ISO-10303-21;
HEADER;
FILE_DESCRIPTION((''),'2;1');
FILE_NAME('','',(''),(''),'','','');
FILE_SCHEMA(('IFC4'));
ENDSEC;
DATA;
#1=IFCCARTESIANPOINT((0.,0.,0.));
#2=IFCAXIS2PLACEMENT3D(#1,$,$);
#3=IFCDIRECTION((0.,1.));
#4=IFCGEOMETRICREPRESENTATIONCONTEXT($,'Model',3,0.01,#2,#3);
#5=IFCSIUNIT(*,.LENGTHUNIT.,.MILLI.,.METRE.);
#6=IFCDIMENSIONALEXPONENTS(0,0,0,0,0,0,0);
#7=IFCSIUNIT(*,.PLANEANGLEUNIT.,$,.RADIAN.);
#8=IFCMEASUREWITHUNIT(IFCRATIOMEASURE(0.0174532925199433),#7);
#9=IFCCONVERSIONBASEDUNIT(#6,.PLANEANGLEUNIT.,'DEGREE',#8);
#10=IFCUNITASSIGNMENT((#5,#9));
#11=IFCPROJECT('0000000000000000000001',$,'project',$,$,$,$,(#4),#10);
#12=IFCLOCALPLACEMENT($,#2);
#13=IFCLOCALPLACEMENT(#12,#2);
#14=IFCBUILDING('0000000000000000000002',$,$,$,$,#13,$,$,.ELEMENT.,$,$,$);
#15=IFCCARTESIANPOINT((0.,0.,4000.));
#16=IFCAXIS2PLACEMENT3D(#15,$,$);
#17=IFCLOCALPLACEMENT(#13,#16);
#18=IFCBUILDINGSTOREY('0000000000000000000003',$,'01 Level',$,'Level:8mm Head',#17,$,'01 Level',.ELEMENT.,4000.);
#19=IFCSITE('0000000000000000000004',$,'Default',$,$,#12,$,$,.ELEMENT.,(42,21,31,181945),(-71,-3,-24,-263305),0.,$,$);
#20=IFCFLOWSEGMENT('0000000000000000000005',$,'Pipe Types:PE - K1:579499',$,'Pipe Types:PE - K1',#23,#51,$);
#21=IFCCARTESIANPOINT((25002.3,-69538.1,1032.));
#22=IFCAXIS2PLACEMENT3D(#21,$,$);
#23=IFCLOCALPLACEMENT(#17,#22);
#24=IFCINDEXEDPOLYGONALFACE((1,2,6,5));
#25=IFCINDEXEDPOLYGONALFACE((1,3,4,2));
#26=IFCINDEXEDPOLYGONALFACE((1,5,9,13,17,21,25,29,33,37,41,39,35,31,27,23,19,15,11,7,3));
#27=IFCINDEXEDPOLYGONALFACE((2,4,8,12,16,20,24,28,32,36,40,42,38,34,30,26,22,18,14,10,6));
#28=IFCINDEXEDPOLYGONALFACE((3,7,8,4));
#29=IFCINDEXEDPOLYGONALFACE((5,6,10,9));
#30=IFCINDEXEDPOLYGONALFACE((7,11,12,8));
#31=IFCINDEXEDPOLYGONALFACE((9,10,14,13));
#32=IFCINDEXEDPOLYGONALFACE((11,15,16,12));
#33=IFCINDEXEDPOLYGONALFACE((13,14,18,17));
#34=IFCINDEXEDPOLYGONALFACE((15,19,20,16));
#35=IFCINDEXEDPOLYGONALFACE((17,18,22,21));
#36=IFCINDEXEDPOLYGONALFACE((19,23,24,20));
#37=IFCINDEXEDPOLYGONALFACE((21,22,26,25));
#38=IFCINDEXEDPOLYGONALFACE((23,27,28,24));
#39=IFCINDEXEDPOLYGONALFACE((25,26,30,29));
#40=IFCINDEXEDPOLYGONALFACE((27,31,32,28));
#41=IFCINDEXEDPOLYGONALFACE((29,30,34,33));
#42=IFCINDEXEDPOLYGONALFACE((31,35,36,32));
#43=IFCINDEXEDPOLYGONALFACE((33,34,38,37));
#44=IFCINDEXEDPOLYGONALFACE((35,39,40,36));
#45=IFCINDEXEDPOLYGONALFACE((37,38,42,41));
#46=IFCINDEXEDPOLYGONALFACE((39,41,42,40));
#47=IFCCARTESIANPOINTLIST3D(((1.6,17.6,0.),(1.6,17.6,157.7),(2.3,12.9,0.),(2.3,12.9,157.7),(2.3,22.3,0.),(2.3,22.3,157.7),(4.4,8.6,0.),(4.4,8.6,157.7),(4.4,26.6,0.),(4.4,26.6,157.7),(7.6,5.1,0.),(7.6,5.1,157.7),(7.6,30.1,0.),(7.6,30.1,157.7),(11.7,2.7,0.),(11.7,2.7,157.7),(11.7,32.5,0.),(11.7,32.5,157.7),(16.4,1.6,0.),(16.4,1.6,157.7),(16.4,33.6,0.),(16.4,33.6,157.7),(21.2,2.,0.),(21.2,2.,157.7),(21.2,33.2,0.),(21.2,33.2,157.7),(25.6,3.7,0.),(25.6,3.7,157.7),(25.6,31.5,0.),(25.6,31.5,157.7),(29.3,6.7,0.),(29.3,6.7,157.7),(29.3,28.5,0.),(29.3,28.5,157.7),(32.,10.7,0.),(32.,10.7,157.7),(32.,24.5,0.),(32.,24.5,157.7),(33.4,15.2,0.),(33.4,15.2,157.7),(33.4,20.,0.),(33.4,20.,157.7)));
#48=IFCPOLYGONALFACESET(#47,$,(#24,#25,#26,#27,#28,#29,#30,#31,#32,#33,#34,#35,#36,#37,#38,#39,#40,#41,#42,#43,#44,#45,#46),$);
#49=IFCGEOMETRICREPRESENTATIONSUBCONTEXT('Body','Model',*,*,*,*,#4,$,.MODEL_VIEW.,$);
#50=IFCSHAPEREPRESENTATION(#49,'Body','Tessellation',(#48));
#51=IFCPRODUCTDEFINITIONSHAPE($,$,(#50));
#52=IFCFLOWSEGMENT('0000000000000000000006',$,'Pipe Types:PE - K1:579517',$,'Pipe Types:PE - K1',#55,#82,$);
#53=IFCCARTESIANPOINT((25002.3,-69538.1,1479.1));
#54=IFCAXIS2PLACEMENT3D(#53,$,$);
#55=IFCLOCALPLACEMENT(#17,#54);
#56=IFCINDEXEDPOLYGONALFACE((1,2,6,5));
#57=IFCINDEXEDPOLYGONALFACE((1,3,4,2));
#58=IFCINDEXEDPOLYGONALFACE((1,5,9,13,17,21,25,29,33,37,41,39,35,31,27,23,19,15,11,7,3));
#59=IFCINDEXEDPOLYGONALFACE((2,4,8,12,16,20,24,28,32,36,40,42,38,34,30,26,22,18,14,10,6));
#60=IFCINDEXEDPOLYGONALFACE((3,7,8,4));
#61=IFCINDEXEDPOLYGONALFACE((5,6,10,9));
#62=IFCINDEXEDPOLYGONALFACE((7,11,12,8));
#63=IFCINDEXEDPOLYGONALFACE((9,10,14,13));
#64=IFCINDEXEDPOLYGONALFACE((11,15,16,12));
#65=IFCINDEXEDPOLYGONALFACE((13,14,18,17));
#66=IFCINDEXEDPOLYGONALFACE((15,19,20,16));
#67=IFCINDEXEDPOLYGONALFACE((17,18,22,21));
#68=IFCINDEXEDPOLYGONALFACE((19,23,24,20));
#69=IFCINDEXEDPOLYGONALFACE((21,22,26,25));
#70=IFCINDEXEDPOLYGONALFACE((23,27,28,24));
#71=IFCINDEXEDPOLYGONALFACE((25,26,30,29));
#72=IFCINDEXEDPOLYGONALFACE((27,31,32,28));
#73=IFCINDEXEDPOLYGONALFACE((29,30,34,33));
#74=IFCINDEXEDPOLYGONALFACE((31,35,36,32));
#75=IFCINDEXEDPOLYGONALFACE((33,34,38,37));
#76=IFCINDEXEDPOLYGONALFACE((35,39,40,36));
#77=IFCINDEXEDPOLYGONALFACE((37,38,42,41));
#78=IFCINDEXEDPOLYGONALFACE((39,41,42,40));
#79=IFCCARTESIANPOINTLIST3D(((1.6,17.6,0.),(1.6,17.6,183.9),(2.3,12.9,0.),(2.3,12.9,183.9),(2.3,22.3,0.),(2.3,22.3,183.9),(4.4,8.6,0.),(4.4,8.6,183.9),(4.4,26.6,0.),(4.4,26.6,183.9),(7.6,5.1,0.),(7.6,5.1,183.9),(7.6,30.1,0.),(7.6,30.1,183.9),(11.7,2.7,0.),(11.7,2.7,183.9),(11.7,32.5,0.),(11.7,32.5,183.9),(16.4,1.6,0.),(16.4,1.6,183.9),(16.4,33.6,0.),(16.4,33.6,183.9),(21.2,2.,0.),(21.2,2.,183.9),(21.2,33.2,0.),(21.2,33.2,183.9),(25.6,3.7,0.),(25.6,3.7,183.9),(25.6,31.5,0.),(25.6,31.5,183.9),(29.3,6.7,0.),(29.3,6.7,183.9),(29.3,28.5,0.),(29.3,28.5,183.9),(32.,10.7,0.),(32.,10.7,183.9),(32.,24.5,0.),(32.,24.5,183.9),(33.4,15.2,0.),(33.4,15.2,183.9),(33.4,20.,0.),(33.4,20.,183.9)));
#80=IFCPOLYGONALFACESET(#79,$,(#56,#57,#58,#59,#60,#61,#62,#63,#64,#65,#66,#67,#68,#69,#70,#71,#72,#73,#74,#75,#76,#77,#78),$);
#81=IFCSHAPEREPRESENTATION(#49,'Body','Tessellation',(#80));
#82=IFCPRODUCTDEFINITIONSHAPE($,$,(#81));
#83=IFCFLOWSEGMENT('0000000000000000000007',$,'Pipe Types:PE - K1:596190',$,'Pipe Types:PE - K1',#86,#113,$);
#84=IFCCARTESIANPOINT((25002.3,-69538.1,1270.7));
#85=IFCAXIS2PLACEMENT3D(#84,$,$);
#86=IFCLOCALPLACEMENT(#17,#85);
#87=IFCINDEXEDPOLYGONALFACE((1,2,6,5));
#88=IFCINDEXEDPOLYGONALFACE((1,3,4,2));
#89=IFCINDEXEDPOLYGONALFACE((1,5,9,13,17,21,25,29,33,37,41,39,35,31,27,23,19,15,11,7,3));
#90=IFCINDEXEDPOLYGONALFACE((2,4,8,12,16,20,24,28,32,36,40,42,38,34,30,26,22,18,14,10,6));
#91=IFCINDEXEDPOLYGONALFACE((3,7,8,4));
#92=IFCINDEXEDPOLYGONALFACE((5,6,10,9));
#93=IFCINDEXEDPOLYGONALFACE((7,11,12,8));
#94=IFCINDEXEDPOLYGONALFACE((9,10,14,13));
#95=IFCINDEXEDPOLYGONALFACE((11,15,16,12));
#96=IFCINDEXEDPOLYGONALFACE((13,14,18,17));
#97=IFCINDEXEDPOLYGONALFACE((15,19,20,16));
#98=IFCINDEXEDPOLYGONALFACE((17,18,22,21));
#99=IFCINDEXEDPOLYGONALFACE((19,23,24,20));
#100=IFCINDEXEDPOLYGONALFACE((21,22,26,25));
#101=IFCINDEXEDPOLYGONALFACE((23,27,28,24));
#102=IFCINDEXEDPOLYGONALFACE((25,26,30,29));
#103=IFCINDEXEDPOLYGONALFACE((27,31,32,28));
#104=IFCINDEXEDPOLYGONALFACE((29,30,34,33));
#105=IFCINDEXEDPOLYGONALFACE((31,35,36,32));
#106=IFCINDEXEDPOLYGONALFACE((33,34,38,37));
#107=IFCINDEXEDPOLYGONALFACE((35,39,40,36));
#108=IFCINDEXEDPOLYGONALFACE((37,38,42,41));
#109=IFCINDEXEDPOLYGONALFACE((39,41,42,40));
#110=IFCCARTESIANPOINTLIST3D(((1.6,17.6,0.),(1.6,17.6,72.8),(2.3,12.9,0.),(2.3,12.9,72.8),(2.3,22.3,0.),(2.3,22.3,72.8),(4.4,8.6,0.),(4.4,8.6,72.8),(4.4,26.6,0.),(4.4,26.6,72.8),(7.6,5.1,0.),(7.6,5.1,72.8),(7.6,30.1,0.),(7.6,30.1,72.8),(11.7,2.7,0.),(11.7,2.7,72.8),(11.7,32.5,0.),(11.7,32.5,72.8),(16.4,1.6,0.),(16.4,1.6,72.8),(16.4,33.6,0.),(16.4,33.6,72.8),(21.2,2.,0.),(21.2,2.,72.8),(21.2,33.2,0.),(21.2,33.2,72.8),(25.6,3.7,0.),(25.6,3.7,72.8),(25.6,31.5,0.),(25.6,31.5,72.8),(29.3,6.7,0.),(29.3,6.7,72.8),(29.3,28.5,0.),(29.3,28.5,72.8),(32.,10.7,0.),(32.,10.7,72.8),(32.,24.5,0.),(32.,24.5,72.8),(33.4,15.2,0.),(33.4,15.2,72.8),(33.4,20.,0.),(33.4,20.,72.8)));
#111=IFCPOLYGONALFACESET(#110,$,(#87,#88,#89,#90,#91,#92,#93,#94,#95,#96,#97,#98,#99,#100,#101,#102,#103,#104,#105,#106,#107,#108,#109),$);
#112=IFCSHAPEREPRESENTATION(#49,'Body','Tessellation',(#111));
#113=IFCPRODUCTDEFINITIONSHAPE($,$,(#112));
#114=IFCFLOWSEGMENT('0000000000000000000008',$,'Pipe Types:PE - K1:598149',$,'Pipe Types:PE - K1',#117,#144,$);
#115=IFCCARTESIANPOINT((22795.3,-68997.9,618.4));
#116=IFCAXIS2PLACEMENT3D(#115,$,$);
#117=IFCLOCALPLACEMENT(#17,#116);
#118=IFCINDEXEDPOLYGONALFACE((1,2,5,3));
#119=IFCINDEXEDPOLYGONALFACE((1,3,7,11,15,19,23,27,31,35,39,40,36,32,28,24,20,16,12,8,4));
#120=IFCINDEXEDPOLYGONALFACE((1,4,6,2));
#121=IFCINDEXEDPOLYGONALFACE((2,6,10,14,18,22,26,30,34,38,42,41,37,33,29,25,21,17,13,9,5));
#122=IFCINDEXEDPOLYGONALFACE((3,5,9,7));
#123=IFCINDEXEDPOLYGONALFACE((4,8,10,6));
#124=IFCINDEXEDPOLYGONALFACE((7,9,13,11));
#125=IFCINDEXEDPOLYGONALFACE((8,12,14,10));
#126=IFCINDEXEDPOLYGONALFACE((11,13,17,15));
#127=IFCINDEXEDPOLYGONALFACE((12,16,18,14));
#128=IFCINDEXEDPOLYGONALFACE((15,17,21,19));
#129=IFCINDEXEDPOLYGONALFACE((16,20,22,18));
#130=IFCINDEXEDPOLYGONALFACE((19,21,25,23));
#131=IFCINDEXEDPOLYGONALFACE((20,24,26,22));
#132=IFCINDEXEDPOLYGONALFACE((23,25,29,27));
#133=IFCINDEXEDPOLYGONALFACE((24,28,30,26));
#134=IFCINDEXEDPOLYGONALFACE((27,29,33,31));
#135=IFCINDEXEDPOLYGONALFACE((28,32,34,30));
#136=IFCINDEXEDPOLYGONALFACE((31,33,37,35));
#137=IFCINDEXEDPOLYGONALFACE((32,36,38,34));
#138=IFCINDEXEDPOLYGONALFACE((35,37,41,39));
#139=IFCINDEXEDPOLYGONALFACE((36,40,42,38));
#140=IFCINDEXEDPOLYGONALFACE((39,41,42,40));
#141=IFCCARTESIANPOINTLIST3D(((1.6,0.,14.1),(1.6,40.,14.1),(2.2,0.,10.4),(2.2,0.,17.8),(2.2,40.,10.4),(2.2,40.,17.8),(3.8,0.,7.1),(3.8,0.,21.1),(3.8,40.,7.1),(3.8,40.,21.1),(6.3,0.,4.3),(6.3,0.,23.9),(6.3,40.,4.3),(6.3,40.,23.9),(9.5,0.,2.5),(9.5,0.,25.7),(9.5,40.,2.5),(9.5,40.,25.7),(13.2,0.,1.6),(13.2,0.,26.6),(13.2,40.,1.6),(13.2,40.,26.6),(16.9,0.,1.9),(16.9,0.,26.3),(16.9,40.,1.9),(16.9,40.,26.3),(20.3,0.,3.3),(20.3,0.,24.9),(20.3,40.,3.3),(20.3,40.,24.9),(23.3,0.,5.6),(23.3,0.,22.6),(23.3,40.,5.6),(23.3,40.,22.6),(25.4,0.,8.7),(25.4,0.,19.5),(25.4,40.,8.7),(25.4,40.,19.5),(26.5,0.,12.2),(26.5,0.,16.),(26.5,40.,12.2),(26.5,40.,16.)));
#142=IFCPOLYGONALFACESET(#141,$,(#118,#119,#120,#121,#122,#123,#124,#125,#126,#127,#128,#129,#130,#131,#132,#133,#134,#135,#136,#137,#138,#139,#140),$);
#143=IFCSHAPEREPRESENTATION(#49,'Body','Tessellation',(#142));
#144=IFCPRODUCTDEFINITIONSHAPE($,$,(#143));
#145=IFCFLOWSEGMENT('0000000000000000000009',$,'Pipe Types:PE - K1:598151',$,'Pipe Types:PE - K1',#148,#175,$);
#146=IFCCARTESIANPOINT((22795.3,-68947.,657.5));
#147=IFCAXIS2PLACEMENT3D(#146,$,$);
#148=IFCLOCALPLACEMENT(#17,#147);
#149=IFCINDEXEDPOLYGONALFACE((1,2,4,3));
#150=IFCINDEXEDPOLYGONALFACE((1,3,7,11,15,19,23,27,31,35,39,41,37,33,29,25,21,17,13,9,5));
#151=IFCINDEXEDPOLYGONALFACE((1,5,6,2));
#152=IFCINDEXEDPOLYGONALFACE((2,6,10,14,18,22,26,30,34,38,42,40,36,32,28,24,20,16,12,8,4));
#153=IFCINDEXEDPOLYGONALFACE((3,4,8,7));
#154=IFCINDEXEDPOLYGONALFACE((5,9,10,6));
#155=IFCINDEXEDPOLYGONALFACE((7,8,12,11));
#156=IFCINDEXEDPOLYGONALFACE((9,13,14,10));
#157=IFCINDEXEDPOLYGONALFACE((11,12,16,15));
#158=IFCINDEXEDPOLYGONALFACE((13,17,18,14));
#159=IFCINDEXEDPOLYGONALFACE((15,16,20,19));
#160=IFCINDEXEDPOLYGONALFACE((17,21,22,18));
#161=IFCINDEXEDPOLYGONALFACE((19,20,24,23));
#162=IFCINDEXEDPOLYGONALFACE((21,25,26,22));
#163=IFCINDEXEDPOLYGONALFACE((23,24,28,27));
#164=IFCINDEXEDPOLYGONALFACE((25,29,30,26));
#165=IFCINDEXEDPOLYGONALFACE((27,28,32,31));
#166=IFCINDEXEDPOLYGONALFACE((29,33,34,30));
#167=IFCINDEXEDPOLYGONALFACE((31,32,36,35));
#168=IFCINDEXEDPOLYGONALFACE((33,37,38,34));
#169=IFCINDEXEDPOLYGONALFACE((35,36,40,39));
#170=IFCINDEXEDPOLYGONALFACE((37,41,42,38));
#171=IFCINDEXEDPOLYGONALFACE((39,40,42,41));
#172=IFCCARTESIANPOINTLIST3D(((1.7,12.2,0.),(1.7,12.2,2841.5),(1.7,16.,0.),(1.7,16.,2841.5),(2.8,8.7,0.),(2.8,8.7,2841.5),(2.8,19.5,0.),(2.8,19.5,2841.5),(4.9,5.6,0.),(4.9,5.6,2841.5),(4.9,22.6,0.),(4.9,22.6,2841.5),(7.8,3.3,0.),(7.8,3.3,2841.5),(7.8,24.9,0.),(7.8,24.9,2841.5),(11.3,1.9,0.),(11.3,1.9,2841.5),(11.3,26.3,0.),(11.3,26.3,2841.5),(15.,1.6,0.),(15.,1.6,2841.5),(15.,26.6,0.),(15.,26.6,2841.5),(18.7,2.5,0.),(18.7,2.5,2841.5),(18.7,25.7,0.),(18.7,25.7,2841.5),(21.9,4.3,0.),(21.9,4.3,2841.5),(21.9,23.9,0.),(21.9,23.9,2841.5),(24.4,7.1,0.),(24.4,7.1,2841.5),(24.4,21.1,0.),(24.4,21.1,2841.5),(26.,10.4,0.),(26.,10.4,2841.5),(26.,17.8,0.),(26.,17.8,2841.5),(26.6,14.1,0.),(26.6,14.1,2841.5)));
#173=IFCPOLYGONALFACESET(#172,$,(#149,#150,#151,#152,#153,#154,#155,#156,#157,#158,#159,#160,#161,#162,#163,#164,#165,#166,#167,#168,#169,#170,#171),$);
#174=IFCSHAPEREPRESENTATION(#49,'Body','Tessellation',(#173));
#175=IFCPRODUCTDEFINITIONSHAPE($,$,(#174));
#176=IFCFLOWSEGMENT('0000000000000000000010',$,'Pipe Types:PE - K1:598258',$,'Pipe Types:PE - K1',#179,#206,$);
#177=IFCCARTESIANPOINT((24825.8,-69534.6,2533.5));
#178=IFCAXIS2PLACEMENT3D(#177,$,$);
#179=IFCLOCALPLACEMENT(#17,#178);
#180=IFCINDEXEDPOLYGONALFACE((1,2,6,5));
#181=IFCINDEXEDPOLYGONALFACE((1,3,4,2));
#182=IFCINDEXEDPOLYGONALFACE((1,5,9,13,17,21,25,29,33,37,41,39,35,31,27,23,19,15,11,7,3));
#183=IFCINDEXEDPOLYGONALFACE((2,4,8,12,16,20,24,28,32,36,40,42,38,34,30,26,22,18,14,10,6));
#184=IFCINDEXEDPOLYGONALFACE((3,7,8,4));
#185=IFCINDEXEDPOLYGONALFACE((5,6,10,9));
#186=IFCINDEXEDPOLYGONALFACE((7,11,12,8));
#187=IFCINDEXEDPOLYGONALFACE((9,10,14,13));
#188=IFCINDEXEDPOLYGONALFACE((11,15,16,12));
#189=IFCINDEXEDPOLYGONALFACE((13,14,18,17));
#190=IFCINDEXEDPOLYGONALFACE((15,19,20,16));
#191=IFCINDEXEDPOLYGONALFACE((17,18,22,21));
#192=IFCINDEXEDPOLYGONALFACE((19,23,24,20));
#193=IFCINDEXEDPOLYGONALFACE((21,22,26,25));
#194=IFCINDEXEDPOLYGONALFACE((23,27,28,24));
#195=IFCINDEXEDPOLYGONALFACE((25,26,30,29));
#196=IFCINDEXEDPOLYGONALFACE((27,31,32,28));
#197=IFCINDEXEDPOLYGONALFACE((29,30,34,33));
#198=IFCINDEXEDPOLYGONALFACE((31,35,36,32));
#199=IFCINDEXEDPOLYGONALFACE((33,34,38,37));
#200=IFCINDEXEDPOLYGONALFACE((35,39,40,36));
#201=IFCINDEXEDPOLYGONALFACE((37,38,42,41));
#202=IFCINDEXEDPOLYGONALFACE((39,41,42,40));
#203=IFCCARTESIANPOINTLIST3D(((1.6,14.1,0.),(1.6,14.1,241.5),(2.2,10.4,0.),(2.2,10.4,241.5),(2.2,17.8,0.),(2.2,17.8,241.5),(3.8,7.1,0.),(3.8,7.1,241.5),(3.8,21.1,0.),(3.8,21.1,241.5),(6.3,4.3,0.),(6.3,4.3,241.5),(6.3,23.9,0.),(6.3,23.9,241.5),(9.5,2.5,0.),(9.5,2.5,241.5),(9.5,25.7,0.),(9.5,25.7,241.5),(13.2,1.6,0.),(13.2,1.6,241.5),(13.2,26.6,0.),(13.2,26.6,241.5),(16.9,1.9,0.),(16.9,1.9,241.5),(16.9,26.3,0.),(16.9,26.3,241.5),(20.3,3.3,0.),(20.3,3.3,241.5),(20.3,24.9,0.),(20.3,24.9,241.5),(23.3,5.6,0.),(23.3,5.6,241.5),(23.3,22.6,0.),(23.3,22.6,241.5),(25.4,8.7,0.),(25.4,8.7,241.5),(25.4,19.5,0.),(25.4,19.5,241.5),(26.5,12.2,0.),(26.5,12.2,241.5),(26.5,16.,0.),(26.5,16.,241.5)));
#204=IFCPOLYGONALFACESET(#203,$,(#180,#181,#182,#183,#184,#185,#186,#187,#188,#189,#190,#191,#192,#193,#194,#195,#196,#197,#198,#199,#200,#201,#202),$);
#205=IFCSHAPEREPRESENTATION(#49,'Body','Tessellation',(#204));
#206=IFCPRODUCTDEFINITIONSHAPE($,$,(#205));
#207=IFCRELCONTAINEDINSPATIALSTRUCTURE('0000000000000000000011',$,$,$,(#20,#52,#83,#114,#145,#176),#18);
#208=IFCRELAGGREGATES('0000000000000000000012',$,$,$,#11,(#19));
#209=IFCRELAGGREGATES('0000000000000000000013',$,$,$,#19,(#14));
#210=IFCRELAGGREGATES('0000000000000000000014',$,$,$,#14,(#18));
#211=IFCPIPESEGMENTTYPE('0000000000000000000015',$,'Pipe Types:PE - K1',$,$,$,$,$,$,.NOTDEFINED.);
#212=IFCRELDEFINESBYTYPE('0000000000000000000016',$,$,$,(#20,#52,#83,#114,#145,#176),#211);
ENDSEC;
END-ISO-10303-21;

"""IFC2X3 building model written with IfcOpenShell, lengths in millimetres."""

from ifc_helpers import new_model, entity, si_unit, converted_unit, direction, frame, frame_2d, origin, origin_2d_with_axis, place, context, subcontext, project, spatial, circle, extrude, type_object, element, save


model = new_model("IFC2X3")

# Units and contexts
model_context = context("Model", 3, precision=0.01, world=origin(), true_north=direction((0.0, 1.0)))
body_context = subcontext(model_context, "Body", "Model", "MODEL_VIEW")
ifc_project = project(units=[si_unit("LENGTHUNIT", "METRE", prefix="MILLI"), converted_unit("PLANEANGLEUNIT", "DEGREE", entity("IfcRatioMeasure", 0.0174532925199433), si_unit("PLANEANGLEUNIT", "RADIAN"), dimensions=[0, 0, 0, 0, 0, 0, 0])], contexts=[model_context])

# Site, building, storey
site_placement = place(None, origin())
site = spatial("IfcSite", under=ifc_project, at=site_placement, Name="Default", CompositionType="ELEMENT", RefLatitude=(42, 21, 31, 181945), RefLongitude=(-71, -3, -24, -263305), RefElevation=0.0)
building_placement = place(site_placement, origin())
building = spatial("IfcBuilding", under=site, at=building_placement, CompositionType="ELEMENT")
storey_placement = place(building_placement, frame((0.0, 0.0, 4000.0)))
storey = spatial("IfcBuildingStorey", under=building, at=storey_placement, Name="01 Level", ObjectType="Level:8mm Head", LongName="01 Level", CompositionType="ELEMENT", Elevation=4000.0)

# Flow segments
pipe_segment_type = type_object("IfcPipeSegmentType", Name="Pipe Types:PE - K1", PredefinedType="NOTDEFINED")
flow_segment_1_placement = place(storey_placement, frame((25002.3, -69538.1, 1032.0)))
element("IfcFlowSegment", 1, at=flow_segment_1_placement, inside=storey, type_object=pipe_segment_type, Name="Pipe Types:PE - K1:579499", ObjectType="Pipe Types:PE - K1", context=body_context, shape_type="SweptSolid", body=[
    extrude(circle(Radius=16.0, at=origin_2d_with_axis()), frame((17.6, 17.6, 0.0), z_axis=(0.0, 0.0, 1.0), x_axis=(-1.0, 0.0, 0.0)), (0.0, 0.0, 1.0), 157.7),
])
flow_segment_2_placement = place(storey_placement, frame((25002.3, -69538.1, 1479.1)))
element("IfcFlowSegment", 2, at=flow_segment_2_placement, inside=storey, type_object=pipe_segment_type, Name="Pipe Types:PE - K1:579517", ObjectType="Pipe Types:PE - K1", context=body_context, shape_type="SweptSolid", body=[
    extrude(circle(Radius=16.0, at=origin_2d_with_axis()), frame((17.6, 17.6, 0.0), z_axis=(0.0, 0.0, 1.0), x_axis=(-1.0, 0.0, 0.0)), (0.0, 0.0, 1.0), 183.9),
])
flow_segment_3_placement = place(storey_placement, frame((25002.3, -69538.1, 1270.7)))
element("IfcFlowSegment", 3, at=flow_segment_3_placement, inside=storey, type_object=pipe_segment_type, Name="Pipe Types:PE - K1:596190", ObjectType="Pipe Types:PE - K1", context=body_context, shape_type="SweptSolid", body=[
    extrude(circle(Radius=16.0, at=origin_2d_with_axis()), frame((17.6, 17.6, 0.0), z_axis=(0.0, 0.0, 1.0), x_axis=(-1.0, 0.0, 0.0)), (0.0, 0.0, 1.0), 72.8),
])
flow_segment_4_placement = place(storey_placement, frame((22795.3, -68997.9, 618.4)))
element("IfcFlowSegment", 4, at=flow_segment_4_placement, inside=storey, type_object=pipe_segment_type, Name="Pipe Types:PE - K1:598149", ObjectType="Pipe Types:PE - K1", context=body_context, shape_type="SweptSolid", body=[
    extrude(circle(Radius=12.5, at=origin_2d_with_axis()), frame((14.1, 0.0, 14.1), z_axis=(0.0, 1.0, 0.0), x_axis=(-1.0, 0.0, 0.0)), (0.0, 0.0, 1.0), 40.0),
])
flow_segment_5_placement = place(storey_placement, frame((22795.3, -68947.0, 657.5)))
element("IfcFlowSegment", 5, at=flow_segment_5_placement, inside=storey, type_object=pipe_segment_type, Name="Pipe Types:PE - K1:598151", ObjectType="Pipe Types:PE - K1", context=body_context, shape_type="SweptSolid", body=[
    extrude(circle(Radius=12.5, at=frame_2d((0.0, 0.0), x_axis=(1.0, 0.0))), frame((14.1, 14.1, 0.0)), (0.0, 0.0, 1.0), 2841.5),
])
flow_segment_6_placement = place(storey_placement, frame((24825.8, -69534.6, 2533.5)))
element("IfcFlowSegment", 6, at=flow_segment_6_placement, inside=storey, type_object=pipe_segment_type, Name="Pipe Types:PE - K1:598258", ObjectType="Pipe Types:PE - K1", context=body_context, shape_type="SweptSolid", body=[
    extrude(circle(Radius=12.5, at=frame_2d((0.0, 0.0), x_axis=(1.0, 0.0))), frame((14.1, 14.1, 0.0), z_axis=(0.0, 0.0, 1.0), x_axis=(-1.0, 0.0, 0.0)), (0.0, 0.0, 1.0), 241.5),
])

save(model, "model.ifc")
